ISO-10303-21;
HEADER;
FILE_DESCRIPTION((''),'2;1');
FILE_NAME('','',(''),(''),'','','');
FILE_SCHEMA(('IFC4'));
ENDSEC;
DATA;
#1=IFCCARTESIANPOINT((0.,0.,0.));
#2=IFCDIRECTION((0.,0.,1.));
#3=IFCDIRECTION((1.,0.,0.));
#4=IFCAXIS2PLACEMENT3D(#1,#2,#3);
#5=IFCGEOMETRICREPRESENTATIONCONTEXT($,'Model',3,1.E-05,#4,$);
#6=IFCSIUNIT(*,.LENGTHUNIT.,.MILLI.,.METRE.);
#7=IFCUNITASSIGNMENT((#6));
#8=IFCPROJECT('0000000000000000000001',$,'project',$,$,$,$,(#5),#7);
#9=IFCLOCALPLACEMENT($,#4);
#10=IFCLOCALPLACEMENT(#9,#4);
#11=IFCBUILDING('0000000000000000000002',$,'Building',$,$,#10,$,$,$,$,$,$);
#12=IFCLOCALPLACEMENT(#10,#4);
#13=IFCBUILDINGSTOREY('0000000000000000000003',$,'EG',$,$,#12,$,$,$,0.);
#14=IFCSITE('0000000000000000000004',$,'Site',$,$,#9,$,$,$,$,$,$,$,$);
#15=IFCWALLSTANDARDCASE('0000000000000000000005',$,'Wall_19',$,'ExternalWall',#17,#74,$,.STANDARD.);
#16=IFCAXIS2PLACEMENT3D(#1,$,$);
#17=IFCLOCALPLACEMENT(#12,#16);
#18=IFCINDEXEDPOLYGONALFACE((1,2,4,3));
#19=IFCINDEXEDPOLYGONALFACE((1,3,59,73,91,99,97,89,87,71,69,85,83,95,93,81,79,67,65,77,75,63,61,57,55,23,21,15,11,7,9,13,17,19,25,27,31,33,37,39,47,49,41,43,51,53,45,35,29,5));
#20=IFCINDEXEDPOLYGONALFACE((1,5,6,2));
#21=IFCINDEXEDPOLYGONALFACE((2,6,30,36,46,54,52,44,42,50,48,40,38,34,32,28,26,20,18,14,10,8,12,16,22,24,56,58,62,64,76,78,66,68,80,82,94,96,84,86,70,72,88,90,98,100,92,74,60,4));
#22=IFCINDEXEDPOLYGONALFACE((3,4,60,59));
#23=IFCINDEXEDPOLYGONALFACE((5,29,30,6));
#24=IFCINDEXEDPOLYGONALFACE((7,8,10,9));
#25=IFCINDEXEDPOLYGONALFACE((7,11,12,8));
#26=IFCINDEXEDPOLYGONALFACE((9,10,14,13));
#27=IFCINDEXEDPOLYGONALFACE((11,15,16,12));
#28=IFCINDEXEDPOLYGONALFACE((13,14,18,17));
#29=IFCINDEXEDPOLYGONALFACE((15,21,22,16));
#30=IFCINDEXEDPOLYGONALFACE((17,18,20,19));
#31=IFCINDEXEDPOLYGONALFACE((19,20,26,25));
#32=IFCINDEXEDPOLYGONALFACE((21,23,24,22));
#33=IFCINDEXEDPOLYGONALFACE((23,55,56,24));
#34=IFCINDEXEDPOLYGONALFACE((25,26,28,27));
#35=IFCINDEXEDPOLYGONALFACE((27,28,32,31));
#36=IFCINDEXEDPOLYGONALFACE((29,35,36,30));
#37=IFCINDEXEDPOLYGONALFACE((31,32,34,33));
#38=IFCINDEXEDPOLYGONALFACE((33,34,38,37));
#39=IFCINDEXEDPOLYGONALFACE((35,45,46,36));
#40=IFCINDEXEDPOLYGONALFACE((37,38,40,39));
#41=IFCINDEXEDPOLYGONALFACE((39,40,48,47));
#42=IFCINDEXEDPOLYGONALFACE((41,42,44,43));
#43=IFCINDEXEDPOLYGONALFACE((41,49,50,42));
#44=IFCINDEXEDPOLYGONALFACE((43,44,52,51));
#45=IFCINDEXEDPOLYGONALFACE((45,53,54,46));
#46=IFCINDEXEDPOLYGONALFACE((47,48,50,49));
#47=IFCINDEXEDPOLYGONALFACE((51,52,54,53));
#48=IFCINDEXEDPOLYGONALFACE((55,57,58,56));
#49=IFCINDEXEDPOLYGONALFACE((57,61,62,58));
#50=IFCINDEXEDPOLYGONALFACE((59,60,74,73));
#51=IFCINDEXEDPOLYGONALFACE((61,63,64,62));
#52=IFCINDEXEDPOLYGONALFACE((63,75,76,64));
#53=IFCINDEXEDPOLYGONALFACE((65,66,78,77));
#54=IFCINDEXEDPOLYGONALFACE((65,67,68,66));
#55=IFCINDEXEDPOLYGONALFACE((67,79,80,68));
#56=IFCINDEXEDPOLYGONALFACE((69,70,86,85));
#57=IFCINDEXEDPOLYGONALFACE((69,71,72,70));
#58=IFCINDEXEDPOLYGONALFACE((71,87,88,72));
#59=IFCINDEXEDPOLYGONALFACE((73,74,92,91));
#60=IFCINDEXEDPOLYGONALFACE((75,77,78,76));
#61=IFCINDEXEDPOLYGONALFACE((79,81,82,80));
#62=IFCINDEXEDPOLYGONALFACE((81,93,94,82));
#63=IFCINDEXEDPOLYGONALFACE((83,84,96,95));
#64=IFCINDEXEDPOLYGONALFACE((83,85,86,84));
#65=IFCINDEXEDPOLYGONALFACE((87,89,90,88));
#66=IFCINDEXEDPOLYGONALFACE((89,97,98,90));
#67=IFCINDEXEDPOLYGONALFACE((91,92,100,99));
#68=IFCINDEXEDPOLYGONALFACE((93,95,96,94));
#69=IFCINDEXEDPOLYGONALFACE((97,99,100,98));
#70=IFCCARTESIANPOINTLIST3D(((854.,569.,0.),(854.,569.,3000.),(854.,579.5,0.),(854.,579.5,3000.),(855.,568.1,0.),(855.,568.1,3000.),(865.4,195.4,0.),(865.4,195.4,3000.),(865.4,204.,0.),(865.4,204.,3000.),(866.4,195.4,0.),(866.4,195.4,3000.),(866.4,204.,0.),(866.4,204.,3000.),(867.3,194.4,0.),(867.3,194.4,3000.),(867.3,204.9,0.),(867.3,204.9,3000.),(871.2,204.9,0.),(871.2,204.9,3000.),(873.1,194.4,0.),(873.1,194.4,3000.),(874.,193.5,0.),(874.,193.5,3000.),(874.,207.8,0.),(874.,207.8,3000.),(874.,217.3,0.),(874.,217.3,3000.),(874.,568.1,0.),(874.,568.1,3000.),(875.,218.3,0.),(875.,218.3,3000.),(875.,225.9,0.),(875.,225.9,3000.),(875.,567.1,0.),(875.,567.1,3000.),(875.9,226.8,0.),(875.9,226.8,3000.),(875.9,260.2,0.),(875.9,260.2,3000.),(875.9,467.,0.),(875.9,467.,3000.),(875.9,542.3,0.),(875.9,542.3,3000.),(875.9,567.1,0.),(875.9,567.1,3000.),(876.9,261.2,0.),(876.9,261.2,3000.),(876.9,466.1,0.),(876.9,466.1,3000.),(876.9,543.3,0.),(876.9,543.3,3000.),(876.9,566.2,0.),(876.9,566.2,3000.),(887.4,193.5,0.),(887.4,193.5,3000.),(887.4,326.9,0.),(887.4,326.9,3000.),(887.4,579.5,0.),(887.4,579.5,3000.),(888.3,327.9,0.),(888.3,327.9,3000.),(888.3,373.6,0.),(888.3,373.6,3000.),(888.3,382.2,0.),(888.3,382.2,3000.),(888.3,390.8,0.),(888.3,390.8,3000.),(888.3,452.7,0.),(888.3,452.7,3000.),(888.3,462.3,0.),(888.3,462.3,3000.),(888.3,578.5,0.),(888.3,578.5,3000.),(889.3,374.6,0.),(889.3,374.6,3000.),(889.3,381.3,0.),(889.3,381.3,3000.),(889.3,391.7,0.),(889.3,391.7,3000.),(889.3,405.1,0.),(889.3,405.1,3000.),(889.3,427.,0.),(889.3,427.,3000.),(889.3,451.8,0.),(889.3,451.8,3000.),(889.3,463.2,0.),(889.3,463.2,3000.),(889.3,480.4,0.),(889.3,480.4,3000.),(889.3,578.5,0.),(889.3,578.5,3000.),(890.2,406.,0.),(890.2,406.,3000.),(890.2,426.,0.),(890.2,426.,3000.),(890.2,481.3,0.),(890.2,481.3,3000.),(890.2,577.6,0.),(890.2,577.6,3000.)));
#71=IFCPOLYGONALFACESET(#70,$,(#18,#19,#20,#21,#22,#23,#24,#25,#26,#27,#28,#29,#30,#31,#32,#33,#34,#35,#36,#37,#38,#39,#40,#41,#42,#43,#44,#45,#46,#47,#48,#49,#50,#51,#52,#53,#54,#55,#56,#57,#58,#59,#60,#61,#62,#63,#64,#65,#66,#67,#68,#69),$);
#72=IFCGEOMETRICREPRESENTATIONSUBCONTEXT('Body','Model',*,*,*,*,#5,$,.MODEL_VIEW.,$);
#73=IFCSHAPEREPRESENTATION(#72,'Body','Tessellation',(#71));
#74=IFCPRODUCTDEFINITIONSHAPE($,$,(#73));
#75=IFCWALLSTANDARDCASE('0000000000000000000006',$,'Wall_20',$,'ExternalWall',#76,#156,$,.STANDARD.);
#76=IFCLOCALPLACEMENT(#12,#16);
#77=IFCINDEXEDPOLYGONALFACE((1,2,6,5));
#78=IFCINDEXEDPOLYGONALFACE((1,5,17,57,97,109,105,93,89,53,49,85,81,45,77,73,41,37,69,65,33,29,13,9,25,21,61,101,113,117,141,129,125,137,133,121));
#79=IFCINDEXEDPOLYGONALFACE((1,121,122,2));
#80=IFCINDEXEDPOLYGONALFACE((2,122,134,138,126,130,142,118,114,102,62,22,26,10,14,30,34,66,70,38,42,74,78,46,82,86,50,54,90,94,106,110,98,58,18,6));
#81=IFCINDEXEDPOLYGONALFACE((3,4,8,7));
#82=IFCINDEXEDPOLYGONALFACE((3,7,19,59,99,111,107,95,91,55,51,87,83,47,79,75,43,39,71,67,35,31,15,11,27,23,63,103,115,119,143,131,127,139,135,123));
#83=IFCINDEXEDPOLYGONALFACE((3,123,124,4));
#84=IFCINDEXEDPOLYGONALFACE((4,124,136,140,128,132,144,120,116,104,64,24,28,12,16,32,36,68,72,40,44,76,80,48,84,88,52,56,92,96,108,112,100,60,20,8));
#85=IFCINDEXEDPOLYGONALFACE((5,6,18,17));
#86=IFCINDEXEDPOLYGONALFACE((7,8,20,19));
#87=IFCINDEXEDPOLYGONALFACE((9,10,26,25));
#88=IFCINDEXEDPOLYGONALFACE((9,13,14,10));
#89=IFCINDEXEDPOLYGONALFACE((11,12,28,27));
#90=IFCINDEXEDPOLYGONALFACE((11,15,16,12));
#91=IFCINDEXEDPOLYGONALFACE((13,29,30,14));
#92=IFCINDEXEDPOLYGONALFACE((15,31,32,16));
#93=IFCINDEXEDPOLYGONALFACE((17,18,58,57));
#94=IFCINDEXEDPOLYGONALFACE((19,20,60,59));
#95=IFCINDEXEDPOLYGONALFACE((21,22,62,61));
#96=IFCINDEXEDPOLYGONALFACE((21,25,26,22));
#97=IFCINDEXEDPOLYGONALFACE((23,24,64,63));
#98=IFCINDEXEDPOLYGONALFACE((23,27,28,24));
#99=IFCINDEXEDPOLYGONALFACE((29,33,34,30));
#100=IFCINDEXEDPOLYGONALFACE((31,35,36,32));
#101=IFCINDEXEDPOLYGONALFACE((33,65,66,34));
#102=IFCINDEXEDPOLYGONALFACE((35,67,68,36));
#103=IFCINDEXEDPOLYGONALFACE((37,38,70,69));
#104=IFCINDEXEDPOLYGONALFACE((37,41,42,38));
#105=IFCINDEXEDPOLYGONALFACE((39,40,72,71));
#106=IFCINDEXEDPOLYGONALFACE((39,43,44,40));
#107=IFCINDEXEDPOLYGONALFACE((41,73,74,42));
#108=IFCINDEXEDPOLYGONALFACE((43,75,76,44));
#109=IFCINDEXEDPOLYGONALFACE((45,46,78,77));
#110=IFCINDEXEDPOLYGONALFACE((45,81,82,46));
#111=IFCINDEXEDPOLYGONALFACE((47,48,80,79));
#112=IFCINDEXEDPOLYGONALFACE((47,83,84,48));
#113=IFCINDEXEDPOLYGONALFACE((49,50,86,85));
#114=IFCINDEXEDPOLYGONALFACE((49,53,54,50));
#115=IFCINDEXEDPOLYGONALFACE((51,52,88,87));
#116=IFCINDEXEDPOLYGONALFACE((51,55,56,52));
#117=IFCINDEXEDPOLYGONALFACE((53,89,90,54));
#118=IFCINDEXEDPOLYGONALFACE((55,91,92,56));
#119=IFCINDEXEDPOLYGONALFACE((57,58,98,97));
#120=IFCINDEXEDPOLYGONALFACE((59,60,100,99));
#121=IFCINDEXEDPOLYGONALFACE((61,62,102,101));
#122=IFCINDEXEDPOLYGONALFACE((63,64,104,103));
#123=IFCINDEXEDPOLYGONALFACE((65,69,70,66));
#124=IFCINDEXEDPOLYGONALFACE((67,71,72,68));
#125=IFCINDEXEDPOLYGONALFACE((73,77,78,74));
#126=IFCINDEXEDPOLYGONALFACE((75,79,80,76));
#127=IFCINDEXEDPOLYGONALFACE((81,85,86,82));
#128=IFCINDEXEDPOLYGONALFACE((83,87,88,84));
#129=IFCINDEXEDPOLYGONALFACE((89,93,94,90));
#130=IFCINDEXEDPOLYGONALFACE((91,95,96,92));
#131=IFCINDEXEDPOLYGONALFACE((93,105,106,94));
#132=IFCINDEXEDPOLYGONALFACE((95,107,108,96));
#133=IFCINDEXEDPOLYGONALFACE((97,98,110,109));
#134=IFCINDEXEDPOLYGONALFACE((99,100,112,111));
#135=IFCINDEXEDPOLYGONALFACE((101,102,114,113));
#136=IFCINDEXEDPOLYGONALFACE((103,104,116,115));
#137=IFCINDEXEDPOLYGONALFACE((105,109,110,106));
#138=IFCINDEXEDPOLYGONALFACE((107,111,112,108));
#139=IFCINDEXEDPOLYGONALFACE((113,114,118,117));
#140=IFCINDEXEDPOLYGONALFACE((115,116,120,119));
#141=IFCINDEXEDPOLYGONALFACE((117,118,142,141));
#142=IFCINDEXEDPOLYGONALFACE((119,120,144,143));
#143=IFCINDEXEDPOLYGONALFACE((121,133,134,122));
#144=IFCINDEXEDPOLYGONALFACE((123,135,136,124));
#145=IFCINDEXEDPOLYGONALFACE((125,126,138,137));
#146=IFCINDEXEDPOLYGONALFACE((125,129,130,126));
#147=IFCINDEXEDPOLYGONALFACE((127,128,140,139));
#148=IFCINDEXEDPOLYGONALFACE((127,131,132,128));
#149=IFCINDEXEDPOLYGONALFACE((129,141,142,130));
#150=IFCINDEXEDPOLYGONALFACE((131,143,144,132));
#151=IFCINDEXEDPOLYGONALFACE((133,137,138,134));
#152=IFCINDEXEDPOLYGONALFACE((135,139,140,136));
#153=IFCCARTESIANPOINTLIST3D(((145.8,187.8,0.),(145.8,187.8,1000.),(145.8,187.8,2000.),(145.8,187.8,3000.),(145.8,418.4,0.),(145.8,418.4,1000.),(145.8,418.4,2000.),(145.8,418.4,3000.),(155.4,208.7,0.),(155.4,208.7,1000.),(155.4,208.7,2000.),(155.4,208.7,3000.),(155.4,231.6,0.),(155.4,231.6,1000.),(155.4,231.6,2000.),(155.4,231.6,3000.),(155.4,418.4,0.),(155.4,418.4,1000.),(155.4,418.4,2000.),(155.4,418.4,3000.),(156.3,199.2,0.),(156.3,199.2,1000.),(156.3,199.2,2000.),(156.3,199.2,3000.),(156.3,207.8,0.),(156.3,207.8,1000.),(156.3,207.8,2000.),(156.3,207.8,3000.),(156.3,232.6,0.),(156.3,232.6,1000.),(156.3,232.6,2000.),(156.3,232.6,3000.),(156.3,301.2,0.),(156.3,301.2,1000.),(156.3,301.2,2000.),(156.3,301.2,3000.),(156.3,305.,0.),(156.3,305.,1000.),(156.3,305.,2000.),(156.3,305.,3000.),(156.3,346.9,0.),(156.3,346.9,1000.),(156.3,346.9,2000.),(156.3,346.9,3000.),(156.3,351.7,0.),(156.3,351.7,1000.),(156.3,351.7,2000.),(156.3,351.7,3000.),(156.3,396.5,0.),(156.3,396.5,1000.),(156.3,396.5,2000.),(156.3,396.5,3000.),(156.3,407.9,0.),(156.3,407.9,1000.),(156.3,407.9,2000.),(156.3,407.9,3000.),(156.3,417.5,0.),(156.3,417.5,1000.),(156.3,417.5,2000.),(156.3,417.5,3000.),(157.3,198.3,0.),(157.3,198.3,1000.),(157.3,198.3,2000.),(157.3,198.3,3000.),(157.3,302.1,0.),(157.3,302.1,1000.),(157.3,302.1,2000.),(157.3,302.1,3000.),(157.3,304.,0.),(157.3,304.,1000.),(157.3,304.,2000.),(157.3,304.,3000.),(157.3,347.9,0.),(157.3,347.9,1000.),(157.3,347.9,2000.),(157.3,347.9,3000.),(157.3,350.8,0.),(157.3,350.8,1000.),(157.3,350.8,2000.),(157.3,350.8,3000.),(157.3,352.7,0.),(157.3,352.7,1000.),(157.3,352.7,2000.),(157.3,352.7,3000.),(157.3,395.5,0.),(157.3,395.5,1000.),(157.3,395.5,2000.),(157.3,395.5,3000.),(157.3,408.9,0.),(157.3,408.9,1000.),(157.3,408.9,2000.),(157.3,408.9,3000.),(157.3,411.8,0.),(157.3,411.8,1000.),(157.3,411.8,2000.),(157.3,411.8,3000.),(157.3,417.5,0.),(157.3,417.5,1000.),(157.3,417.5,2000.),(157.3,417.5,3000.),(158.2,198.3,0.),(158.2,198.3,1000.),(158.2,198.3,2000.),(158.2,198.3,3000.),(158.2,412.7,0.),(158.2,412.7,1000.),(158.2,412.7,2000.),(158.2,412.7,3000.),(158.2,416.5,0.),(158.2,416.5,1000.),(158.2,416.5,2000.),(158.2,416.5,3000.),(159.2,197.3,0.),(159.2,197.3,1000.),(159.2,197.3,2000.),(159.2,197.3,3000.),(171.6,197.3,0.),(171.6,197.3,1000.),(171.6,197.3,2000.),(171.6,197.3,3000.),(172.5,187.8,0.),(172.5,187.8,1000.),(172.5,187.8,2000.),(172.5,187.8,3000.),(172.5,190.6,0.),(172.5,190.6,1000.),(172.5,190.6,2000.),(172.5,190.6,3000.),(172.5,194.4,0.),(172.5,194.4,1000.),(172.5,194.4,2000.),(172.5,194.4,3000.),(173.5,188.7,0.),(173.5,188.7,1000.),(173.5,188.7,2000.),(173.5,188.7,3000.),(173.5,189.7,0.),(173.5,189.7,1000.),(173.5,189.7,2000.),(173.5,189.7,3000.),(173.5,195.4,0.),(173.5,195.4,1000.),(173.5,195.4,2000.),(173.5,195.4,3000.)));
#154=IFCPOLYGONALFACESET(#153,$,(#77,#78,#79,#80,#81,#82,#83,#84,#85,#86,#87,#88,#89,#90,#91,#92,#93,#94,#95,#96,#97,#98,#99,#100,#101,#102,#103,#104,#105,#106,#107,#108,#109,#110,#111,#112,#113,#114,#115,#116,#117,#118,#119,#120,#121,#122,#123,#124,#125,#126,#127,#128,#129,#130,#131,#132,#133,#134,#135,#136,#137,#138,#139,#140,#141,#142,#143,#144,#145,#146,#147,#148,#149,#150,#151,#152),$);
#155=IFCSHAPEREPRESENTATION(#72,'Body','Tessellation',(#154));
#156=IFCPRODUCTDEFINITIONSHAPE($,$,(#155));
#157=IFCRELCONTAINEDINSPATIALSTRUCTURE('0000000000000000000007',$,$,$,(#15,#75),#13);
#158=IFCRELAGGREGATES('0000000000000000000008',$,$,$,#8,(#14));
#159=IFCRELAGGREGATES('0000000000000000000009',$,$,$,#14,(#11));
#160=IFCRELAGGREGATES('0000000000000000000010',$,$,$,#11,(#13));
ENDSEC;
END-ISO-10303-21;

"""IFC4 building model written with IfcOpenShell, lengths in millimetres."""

from ifc_helpers import new_model, si_unit, frame, origin_with_axes, place, context, subcontext, project, spatial, polyline, rectangle, outline, extrude, element, save


model = new_model("IFC4")

# Units and contexts
model_context = context("Model", 3, precision=1e-05, world=origin_with_axes())
body_context = subcontext(model_context, "Body", "Model", "MODEL_VIEW")
ifc_project = project(units=[si_unit("LENGTHUNIT", "METRE", prefix="MILLI")], contexts=[model_context])

# Site, building, storey
site_placement = place(None, origin_with_axes())
site = spatial("IfcSite", under=ifc_project, at=site_placement, Name="Site")
building_placement = place(site_placement, origin_with_axes())
building = spatial("IfcBuilding", under=site, at=building_placement, Name="Building")
storey_placement = place(building_placement, origin_with_axes())
storey = spatial("IfcBuildingStorey", under=building, at=storey_placement, Name="EG", Elevation=0.0)

# Wall
wall_1_placement = place(storey_placement, origin_with_axes())
element("IfcWallStandardCase", 1, at=wall_1_placement, inside=storey, Name="Wall_19", ObjectType="ExternalWall", PredefinedType="STANDARD", context=body_context, shape_type="SweptSolid", body=[
    extrude(outline(polyline([(874.0, 193.5, 0.0), (873.1, 194.4, 0.0), (867.3, 194.4, 0.0), (866.4, 195.4, 0.0), (865.4, 195.4, 0.0), (865.4, 204.0, 0.0), (866.4, 204.0, 0.0), (867.3, 204.9, 0.0), (871.2, 204.9, 0.0), (874.0, 207.8, 0.0), (874.0, 217.3, 0.0), (875.0, 218.3, 0.0), (875.0, 225.9, 0.0), (875.9, 226.8, 0.0), (875.9, 260.2, 0.0), (876.9, 261.2, 0.0), (876.9, 466.1, 0.0), (875.9, 467.0, 0.0), (875.9, 542.3, 0.0), (876.9, 543.3, 0.0), (876.9, 566.2, 0.0), (875.9, 567.1, 0.0), (875.0, 567.1, 0.0), (874.0, 568.1, 0.0), (855.0, 568.1, 0.0), (854.0, 569.0, 0.0), (854.0, 579.5, 0.0), (887.4, 579.5, 0.0), (888.3, 578.5, 0.0), (889.3, 578.5, 0.0), (890.2, 577.6, 0.0), (890.2, 481.3, 0.0), (889.3, 480.4, 0.0), (889.3, 463.2, 0.0), (888.3, 462.3, 0.0), (888.3, 452.7, 0.0), (889.3, 451.8, 0.0), (889.3, 427.0, 0.0), (890.2, 426.0, 0.0), (890.2, 406.0, 0.0), (889.3, 405.1, 0.0), (889.3, 391.7, 0.0), (888.3, 390.8, 0.0), (888.3, 382.2, 0.0), (889.3, 381.3, 0.0), (889.3, 374.6, 0.0), (888.3, 373.6, 0.0), (888.3, 327.9, 0.0), (887.4, 326.9, 0.0), (887.4, 193.5, 0.0), (874.0, 193.5, 0.0)])), origin_with_axes(), (0.0, 0.0, 1.0), 3000.0),
])

# Wall, opening
wall_2_placement = place(storey_placement, origin_with_axes())
wall_2 = element("IfcWallStandardCase", 2, at=wall_2_placement, inside=storey, Name="Wall_20", ObjectType="ExternalWall", PredefinedType="STANDARD", context=body_context, shape_type="SweptSolid", body=[
    extrude(outline(polyline([(145.8, 187.8, 0.0), (145.8, 418.4, 0.0), (155.4, 418.4, 0.0), (156.3, 417.5, 0.0), (157.3, 417.5, 0.0), (158.2, 416.5, 0.0), (158.2, 412.7, 0.0), (157.3, 411.8, 0.0), (157.3, 408.9, 0.0), (156.3, 407.9, 0.0), (156.3, 396.5, 0.0), (157.3, 395.5, 0.0), (157.3, 352.7, 0.0), (156.3, 351.7, 0.0), (157.3, 350.8, 0.0), (157.3, 347.9, 0.0), (156.3, 346.9, 0.0), (156.3, 305.0, 0.0), (157.3, 304.0, 0.0), (157.3, 302.1, 0.0), (156.3, 301.2, 0.0), (156.3, 232.6, 0.0), (155.4, 231.6, 0.0), (155.4, 208.7, 0.0), (156.3, 207.8, 0.0), (156.3, 199.2, 0.0), (157.3, 198.3, 0.0), (158.2, 198.3, 0.0), (159.2, 197.3, 0.0), (171.6, 197.3, 0.0), (173.5, 195.4, 0.0), (172.5, 194.4, 0.0), (172.5, 190.6, 0.0), (173.5, 189.7, 0.0), (173.5, 188.7, 0.0), (172.5, 187.8, 0.0), (145.8, 187.8, 0.0)])), origin_with_axes(), (0.0, 0.0, 1.0), 3000.0),
])
opening_1_placement = place(wall_2_placement, origin_with_axes())
element("IfcOpeningElement", 3, at=opening_1_placement, inside=storey, cuts=wall_2, context=body_context, shape_type="SweptSolid", body=[
    extrude(rectangle(XDim=600.0, YDim=27.6), frame((159.6, 192.5, 1000.0), z_axis=(0.0, 0.0, 1.0), x_axis=(0.0, -1.0, 0.0)), (0.0, 0.0, 1.0), 1000.0),
])

save(model, "model.ifc")
